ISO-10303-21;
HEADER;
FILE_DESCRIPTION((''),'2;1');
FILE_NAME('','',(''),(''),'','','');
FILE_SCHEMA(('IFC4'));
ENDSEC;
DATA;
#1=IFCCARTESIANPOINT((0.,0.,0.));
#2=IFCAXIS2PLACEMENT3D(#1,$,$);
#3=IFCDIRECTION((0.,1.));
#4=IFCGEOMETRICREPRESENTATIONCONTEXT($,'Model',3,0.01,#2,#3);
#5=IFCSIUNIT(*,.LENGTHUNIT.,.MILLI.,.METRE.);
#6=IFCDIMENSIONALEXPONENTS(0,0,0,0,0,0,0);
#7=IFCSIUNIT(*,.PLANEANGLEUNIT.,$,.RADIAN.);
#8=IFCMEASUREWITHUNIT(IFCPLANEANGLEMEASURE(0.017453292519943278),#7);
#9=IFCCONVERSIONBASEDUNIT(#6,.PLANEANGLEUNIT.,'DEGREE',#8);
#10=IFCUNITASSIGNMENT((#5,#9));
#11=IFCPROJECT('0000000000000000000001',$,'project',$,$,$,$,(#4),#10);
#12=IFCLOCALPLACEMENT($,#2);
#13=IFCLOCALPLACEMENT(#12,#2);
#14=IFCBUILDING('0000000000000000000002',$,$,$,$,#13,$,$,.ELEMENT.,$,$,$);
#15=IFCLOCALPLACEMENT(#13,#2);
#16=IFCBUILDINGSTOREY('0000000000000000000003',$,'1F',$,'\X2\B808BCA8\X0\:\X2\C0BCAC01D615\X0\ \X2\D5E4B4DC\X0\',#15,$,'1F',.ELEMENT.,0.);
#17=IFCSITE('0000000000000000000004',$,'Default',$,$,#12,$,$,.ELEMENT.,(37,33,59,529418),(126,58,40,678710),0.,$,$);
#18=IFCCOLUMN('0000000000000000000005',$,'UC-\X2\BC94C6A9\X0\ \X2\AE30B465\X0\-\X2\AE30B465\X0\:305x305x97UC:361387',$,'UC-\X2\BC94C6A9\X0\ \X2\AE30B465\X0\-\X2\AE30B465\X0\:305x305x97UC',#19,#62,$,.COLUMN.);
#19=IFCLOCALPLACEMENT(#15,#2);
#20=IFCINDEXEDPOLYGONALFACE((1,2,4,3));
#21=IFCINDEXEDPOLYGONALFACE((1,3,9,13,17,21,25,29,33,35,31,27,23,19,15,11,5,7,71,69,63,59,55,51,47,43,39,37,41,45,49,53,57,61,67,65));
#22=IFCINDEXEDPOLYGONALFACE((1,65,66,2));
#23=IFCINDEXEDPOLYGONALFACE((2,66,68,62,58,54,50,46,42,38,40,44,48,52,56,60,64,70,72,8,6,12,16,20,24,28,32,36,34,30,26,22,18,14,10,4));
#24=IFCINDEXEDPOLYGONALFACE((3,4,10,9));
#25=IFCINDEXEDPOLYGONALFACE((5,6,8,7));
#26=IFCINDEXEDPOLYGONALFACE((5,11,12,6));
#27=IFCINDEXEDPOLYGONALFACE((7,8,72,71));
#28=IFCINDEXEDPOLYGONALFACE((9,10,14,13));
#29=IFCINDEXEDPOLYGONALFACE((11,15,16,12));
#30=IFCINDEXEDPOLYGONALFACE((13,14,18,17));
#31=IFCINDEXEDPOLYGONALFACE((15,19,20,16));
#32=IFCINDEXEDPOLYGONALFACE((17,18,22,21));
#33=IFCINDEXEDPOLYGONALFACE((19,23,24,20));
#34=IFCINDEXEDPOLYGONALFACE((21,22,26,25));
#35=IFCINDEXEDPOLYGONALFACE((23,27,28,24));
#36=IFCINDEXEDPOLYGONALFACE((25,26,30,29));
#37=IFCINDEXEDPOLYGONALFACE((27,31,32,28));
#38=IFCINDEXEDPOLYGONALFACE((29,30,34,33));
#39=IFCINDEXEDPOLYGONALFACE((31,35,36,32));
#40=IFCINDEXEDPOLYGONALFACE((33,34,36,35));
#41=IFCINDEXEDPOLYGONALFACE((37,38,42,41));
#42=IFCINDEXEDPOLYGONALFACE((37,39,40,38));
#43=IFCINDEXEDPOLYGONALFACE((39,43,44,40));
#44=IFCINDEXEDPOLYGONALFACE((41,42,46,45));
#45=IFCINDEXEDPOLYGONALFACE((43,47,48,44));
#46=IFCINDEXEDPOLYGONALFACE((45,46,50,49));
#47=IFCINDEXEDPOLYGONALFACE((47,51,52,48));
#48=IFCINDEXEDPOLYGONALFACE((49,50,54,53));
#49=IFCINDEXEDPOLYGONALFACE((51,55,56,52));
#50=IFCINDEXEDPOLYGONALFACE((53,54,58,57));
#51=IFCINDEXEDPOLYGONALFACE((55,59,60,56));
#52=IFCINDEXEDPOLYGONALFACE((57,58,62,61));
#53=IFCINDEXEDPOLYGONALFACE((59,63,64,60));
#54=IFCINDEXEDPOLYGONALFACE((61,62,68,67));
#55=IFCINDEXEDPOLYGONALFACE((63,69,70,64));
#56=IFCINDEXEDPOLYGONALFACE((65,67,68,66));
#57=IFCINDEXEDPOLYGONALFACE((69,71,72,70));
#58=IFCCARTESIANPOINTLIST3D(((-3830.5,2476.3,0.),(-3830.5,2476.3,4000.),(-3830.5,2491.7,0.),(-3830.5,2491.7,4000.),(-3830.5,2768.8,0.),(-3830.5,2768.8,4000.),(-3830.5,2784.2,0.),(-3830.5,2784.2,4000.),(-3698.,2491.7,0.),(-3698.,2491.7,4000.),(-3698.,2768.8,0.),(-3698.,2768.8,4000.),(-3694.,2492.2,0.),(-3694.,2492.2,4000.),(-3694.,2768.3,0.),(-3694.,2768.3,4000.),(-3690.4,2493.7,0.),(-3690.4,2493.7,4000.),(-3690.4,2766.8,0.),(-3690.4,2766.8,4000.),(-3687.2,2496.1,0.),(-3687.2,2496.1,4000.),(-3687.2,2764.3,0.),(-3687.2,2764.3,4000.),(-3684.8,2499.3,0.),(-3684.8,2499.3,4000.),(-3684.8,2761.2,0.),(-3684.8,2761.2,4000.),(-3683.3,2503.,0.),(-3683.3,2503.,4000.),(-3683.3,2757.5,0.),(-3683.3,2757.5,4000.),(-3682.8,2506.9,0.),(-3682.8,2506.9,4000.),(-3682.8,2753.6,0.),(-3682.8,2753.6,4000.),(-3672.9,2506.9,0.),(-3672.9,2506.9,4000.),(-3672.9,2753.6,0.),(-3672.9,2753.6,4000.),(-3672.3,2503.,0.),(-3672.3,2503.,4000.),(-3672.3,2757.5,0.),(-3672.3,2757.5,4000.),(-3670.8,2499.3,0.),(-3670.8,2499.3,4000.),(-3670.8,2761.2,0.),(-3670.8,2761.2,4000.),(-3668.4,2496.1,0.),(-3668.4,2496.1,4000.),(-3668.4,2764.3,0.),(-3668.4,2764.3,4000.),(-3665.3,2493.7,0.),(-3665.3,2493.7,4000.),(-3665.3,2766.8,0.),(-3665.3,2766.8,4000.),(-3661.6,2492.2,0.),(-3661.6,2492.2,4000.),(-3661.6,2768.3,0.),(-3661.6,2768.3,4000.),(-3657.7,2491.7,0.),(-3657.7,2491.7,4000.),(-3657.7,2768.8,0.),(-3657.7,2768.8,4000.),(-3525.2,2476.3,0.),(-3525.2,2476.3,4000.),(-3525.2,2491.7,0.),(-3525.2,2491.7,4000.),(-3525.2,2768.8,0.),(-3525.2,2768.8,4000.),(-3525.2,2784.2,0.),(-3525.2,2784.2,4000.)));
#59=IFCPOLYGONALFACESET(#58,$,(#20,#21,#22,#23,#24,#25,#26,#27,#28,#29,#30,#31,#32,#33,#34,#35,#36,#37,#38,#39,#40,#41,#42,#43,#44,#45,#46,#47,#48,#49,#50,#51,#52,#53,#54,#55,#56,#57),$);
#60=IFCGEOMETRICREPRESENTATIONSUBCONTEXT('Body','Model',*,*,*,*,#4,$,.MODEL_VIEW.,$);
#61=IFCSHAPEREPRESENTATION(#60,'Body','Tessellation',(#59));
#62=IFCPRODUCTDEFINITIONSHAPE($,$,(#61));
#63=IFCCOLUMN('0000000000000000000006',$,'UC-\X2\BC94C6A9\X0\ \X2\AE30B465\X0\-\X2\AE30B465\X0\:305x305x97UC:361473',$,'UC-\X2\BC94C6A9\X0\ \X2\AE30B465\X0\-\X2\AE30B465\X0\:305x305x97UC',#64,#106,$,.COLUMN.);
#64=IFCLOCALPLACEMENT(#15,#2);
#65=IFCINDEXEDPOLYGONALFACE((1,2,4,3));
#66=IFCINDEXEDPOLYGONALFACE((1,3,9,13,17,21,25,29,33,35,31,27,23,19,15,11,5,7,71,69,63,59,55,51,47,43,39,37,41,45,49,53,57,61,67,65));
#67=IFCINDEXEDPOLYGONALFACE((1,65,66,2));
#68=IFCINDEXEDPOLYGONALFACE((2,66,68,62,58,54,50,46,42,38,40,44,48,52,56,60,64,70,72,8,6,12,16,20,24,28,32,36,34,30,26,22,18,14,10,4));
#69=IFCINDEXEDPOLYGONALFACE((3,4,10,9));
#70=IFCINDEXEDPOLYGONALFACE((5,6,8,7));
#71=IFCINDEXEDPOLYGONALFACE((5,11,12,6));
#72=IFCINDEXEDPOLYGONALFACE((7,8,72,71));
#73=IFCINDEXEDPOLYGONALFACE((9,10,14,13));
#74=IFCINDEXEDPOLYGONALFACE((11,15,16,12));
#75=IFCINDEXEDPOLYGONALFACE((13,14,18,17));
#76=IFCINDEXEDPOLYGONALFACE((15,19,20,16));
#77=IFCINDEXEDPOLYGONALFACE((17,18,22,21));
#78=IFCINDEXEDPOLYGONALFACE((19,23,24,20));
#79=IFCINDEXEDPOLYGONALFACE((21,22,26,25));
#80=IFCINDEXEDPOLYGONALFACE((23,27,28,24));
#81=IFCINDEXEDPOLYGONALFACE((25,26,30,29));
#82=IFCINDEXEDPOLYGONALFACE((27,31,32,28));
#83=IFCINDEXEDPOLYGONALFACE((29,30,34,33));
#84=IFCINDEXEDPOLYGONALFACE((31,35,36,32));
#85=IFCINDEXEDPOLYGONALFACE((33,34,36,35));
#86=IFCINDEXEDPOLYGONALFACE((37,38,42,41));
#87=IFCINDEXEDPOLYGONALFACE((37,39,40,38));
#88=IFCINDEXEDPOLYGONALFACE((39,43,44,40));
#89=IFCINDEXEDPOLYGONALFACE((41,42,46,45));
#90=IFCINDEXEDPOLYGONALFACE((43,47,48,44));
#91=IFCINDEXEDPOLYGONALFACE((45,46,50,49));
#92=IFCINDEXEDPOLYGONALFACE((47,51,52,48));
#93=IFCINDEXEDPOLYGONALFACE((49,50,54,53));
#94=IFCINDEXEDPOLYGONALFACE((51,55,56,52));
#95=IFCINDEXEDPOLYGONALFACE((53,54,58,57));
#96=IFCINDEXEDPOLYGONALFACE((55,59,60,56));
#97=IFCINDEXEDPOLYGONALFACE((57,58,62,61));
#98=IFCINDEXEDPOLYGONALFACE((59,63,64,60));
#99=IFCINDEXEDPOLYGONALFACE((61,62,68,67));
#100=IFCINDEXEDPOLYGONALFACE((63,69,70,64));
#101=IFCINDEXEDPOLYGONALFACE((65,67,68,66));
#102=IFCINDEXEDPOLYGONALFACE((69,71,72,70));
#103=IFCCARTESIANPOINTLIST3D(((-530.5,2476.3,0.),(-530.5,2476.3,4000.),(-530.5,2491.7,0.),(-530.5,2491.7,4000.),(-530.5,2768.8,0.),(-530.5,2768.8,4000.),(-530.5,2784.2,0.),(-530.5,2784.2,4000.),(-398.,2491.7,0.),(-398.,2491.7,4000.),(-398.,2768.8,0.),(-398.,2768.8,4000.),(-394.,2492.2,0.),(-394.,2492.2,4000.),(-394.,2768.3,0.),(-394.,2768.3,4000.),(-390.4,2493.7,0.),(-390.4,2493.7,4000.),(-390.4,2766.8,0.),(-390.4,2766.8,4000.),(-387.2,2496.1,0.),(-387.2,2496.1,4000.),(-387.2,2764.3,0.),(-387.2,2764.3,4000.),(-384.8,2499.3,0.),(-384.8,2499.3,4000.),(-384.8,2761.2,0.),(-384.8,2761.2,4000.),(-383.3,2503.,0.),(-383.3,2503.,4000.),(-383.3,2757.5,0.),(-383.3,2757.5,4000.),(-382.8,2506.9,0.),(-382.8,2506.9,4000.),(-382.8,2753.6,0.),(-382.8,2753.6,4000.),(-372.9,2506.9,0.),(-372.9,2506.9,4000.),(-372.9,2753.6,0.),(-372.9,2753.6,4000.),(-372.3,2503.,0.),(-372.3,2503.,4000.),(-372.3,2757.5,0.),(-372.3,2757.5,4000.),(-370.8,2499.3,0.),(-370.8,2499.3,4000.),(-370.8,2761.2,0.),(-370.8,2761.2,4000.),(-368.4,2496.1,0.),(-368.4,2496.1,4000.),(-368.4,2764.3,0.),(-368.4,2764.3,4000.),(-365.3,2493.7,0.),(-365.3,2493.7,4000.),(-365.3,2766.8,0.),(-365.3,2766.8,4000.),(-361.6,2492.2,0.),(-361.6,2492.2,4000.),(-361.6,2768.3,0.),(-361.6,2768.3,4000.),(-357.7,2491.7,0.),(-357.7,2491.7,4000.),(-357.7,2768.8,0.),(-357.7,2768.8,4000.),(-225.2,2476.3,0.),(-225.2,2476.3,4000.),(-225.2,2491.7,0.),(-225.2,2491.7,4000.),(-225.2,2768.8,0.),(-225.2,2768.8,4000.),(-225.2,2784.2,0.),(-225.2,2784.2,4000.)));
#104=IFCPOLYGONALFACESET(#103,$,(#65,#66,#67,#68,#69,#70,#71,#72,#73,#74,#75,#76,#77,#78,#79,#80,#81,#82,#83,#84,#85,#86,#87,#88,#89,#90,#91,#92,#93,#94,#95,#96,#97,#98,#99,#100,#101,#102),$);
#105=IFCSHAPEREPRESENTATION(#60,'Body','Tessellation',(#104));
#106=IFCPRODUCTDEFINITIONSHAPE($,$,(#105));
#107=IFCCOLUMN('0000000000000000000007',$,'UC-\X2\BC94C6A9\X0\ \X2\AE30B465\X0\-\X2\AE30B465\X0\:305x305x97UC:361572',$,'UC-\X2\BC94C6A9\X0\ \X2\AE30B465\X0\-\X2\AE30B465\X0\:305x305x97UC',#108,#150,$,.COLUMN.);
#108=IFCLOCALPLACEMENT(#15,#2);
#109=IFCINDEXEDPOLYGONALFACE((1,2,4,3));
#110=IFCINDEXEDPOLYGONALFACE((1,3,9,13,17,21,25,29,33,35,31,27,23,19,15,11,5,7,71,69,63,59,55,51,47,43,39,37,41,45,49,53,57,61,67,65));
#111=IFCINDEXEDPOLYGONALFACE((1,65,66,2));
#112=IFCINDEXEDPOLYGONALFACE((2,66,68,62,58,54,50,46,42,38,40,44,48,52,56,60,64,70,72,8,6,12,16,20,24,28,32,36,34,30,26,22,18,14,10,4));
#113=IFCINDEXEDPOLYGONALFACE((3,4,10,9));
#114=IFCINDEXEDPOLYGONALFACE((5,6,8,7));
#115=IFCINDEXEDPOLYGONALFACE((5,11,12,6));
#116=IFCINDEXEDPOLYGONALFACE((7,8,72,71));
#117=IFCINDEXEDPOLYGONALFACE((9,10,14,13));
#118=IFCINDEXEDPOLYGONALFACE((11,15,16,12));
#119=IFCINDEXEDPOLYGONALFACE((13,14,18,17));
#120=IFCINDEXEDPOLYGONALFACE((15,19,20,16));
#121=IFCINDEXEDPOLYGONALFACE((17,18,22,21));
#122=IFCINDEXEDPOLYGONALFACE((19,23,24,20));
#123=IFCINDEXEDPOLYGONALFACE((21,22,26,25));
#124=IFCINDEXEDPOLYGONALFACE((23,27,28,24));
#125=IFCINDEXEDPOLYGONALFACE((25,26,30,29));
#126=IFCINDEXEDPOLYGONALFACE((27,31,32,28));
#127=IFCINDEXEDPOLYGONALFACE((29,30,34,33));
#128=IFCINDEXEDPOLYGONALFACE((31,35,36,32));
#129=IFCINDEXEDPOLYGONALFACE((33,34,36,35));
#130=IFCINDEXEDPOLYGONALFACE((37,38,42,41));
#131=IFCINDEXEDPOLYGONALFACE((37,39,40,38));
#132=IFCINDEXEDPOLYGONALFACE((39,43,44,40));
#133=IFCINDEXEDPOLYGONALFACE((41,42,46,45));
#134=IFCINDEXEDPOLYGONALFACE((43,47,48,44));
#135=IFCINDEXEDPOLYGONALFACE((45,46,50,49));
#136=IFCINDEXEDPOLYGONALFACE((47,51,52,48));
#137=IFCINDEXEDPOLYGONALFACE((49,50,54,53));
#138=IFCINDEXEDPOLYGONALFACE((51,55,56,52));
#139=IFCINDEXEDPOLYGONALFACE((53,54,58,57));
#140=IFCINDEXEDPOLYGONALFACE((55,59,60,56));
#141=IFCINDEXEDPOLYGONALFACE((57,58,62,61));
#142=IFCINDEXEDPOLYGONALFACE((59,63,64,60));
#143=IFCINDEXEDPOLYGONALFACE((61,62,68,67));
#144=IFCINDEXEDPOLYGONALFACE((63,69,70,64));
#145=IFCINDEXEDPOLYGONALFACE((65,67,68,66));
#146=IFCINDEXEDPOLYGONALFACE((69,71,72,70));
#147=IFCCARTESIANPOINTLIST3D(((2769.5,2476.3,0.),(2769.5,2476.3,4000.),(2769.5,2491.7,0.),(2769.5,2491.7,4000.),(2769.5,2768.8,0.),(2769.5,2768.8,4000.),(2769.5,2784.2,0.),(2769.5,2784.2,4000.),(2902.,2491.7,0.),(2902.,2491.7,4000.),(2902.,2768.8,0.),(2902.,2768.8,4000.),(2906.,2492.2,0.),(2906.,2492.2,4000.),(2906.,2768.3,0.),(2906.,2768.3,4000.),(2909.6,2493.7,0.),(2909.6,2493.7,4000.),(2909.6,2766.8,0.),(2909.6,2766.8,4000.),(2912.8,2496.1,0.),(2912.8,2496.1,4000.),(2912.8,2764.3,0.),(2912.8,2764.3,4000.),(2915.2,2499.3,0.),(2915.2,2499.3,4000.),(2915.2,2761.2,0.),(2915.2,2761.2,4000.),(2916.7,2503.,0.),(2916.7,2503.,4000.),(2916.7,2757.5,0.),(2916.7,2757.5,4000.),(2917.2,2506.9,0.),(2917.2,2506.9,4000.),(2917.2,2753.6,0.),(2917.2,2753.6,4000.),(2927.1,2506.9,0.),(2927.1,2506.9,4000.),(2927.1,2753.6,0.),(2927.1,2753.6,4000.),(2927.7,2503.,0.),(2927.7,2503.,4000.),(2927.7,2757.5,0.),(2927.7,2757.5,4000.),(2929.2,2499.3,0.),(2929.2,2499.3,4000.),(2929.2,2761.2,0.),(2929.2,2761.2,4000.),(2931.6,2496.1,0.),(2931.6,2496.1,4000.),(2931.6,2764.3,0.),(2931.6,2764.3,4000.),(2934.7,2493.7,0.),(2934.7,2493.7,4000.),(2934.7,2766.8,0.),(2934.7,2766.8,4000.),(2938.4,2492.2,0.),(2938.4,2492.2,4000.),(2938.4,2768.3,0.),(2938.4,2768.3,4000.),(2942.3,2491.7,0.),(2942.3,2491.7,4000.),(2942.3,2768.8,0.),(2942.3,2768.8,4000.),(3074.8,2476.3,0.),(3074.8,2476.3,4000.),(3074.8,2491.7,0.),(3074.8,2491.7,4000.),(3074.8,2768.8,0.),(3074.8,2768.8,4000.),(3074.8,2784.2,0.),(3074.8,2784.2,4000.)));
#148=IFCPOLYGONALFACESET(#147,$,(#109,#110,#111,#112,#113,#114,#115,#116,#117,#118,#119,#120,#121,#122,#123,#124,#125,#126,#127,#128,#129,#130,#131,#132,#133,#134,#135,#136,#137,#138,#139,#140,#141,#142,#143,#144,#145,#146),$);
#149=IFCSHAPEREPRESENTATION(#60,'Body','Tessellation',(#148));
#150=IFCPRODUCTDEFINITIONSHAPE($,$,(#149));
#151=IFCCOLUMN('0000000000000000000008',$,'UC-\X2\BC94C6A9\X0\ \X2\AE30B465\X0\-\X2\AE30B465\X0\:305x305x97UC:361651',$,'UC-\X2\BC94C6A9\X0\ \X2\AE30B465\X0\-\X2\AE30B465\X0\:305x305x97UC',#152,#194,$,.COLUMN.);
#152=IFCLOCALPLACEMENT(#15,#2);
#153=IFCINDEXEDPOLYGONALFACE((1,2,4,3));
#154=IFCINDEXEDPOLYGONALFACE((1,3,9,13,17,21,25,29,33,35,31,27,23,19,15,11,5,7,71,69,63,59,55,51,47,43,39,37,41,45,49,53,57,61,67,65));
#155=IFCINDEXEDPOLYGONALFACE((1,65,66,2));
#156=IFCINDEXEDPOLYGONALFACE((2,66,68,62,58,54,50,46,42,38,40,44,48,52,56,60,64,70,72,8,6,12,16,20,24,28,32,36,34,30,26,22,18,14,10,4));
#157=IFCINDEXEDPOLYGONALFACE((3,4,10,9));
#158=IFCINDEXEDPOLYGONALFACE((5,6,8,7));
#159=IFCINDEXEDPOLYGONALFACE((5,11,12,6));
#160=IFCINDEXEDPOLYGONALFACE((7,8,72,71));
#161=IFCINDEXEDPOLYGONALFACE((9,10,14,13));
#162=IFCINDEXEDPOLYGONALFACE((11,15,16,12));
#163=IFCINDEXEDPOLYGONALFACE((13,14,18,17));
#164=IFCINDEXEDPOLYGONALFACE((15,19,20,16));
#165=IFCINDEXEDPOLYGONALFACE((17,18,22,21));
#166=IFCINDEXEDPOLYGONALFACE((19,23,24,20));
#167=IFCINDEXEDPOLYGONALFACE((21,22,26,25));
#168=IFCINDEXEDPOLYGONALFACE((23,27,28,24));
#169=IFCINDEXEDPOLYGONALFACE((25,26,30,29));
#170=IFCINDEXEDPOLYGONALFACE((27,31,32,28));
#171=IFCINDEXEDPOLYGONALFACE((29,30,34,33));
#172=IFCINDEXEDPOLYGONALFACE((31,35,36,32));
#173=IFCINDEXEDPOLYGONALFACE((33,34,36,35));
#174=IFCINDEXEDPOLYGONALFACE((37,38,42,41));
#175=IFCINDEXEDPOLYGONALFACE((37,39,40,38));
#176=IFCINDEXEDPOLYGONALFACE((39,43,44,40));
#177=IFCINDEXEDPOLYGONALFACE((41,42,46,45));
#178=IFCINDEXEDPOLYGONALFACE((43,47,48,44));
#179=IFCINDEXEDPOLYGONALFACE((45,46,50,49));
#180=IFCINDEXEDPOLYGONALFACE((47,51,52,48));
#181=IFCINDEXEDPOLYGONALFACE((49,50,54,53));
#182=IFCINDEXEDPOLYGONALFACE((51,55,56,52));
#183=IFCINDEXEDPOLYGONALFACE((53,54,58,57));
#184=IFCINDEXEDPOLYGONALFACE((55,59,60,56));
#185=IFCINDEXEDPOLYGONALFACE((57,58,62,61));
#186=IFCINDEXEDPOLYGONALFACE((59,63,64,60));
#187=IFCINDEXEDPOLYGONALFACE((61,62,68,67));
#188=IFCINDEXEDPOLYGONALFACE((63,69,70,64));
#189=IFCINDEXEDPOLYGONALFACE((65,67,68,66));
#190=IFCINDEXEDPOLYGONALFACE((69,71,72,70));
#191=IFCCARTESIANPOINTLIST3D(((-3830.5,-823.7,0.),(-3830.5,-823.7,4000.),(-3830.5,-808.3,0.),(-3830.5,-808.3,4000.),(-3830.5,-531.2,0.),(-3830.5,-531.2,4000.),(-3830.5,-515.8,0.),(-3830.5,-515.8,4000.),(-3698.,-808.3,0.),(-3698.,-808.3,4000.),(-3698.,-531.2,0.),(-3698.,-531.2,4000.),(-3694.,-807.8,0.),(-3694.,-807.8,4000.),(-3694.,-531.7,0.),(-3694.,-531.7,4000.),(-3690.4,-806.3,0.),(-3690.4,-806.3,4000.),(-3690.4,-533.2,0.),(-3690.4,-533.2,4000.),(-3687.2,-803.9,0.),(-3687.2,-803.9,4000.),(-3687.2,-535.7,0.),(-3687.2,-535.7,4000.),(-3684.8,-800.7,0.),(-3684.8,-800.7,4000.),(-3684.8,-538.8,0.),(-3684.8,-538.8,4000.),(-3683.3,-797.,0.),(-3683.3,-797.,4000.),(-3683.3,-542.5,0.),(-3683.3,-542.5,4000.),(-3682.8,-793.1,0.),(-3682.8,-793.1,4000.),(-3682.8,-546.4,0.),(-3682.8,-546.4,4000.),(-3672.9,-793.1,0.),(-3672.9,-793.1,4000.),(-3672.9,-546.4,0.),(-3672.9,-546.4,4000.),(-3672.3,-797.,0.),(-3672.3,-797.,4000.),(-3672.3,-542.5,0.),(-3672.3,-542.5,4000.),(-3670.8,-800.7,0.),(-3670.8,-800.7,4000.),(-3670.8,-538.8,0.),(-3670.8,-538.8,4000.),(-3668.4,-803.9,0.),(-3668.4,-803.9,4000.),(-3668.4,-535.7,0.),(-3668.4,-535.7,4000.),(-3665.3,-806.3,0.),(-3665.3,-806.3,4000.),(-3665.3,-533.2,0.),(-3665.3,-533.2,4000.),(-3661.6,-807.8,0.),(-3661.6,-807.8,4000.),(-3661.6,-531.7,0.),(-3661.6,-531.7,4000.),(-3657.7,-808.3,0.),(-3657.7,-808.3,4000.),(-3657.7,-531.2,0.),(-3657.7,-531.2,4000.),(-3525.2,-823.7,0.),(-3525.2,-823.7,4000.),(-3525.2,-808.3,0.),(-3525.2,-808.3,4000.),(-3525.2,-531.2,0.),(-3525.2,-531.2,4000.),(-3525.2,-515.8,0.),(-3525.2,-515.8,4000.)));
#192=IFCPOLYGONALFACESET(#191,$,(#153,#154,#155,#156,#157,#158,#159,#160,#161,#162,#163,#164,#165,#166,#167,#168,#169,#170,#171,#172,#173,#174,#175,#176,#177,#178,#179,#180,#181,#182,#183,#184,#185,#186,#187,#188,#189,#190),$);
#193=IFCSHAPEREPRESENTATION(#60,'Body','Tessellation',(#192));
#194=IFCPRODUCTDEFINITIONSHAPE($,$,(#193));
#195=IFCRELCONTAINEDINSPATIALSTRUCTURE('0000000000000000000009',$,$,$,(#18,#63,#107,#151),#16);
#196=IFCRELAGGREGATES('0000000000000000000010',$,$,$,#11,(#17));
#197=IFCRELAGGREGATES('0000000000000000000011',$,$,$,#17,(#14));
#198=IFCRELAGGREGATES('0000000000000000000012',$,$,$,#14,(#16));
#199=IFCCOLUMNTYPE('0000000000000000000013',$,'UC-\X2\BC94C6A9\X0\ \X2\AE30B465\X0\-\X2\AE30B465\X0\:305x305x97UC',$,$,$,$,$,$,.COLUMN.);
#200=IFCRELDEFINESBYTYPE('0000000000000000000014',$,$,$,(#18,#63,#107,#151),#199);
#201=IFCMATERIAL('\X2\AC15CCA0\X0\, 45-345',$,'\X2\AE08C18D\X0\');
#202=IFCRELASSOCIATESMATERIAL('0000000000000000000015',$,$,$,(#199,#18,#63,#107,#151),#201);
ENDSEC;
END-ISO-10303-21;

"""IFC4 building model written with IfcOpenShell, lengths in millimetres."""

from ifc_helpers import new_model, entity, si_unit, converted_unit, direction, frame, origin, place, context, subcontext, project, spatial, line, arc, indexed_curve, outline, extrude, source, transform, mapped, material, type_object, type_shapes, element, save


model = new_model("IFC4")

# Units and contexts
model_context = context("Model", 3, precision=0.01, world=origin(), true_north=direction((0.0, 1.0)))
body_context = subcontext(model_context, "Body", "Model", "MODEL_VIEW")
ifc_project = project(units=[si_unit("LENGTHUNIT", "METRE", prefix="MILLI"), converted_unit("PLANEANGLEUNIT", "DEGREE", entity("IfcPlaneAngleMeasure", 0.017453292519943278), si_unit("PLANEANGLEUNIT", "RADIAN"), dimensions=[0, 0, 0, 0, 0, 0, 0])], contexts=[model_context])

# Site, building, storey
site_placement = place(None, origin())
site = spatial("IfcSite", under=ifc_project, at=site_placement, Name="Default", CompositionType="ELEMENT", RefLatitude=(37, 33, 59, 529418), RefLongitude=(126, 58, 40, 678710), RefElevation=0.0)
building_placement = place(site_placement, origin())
building = spatial("IfcBuilding", under=site, at=building_placement, CompositionType="ELEMENT")
storey_placement = place(building_placement, origin())
storey = spatial("IfcBuildingStorey", under=building, at=storey_placement, Name="1F", ObjectType="레벨:삼각형 헤드", LongName="1F", CompositionType="ELEMENT", Elevation=0.0)

# Columns
ifc_material_1 = material(Name="강철, 45-345", Category="금속")
column_type = type_object("IfcColumnType", Name="UC-범용 기둥-기둥:305x305x97UC", PredefinedType="COLUMN", material=ifc_material_1)
shared_shape = source(origin(), body_context, "Body", "SweptSolid", [
    extrude(outline(indexed_curve([(-152.6, -153.9), (152.6, -153.9), (152.6, -138.5), (20.2, -138.5), (9.4, -134.1), (5.0, -123.3), (5.0, 123.3), (9.4, 134.1), (20.2, 138.5), (152.6, 138.5), (152.6, 153.9), (-152.6, 153.9), (-152.6, 138.5), (-20.2, 138.5), (-9.4, 134.1), (-5.0, 123.4), (-5.0, -123.3), (-9.4, -134.1), (-20.2, -138.5), (-152.6, -138.5)], segments=[line(1, 2, 3, 4), arc(4, 5, 6), line(6, 7), arc(7, 8, 9), line(9, 10, 11, 12, 13, 14), arc(14, 15, 16), line(16, 17), arc(17, 18, 19), line(19, 20, 1)], self_intersect=False)), frame((0.0, 0.0, 0.0), z_axis=(0.0, 0.0, 1.0), x_axis=(-1.0, 0.0, 0.0)), (0.0, 0.0, 1.0), 4000.0),
])
type_shapes(column_type, [shared_shape])
for number, where, name in (
    (1, (-3677.8, 2630.2, 0.0), "UC-범용 기둥-기둥:305x305x97UC:361387"),
    (2, (-377.8, 2630.2, 0.0), "UC-범용 기둥-기둥:305x305x97UC:361473"),
    (3, (2922.2, 2630.2, 0.0), "UC-범용 기둥-기둥:305x305x97UC:361572"),
    (4, (-3677.8, -669.8, 0.0), "UC-범용 기둥-기둥:305x305x97UC:361651"),
):
    element("IfcColumn", number, at=place(storey_placement, frame(where)), inside=storey, type_object=column_type, material=ifc_material_1, Name=name, ObjectType="UC-범용 기둥-기둥:305x305x97UC", PredefinedType="COLUMN", context=body_context, shape_type="MappedRepresentation", body=[
        mapped(shared_shape, transform((0.0, 0.0, 0.0), scale=1.0)),
    ])

save(model, "model.ifc")
